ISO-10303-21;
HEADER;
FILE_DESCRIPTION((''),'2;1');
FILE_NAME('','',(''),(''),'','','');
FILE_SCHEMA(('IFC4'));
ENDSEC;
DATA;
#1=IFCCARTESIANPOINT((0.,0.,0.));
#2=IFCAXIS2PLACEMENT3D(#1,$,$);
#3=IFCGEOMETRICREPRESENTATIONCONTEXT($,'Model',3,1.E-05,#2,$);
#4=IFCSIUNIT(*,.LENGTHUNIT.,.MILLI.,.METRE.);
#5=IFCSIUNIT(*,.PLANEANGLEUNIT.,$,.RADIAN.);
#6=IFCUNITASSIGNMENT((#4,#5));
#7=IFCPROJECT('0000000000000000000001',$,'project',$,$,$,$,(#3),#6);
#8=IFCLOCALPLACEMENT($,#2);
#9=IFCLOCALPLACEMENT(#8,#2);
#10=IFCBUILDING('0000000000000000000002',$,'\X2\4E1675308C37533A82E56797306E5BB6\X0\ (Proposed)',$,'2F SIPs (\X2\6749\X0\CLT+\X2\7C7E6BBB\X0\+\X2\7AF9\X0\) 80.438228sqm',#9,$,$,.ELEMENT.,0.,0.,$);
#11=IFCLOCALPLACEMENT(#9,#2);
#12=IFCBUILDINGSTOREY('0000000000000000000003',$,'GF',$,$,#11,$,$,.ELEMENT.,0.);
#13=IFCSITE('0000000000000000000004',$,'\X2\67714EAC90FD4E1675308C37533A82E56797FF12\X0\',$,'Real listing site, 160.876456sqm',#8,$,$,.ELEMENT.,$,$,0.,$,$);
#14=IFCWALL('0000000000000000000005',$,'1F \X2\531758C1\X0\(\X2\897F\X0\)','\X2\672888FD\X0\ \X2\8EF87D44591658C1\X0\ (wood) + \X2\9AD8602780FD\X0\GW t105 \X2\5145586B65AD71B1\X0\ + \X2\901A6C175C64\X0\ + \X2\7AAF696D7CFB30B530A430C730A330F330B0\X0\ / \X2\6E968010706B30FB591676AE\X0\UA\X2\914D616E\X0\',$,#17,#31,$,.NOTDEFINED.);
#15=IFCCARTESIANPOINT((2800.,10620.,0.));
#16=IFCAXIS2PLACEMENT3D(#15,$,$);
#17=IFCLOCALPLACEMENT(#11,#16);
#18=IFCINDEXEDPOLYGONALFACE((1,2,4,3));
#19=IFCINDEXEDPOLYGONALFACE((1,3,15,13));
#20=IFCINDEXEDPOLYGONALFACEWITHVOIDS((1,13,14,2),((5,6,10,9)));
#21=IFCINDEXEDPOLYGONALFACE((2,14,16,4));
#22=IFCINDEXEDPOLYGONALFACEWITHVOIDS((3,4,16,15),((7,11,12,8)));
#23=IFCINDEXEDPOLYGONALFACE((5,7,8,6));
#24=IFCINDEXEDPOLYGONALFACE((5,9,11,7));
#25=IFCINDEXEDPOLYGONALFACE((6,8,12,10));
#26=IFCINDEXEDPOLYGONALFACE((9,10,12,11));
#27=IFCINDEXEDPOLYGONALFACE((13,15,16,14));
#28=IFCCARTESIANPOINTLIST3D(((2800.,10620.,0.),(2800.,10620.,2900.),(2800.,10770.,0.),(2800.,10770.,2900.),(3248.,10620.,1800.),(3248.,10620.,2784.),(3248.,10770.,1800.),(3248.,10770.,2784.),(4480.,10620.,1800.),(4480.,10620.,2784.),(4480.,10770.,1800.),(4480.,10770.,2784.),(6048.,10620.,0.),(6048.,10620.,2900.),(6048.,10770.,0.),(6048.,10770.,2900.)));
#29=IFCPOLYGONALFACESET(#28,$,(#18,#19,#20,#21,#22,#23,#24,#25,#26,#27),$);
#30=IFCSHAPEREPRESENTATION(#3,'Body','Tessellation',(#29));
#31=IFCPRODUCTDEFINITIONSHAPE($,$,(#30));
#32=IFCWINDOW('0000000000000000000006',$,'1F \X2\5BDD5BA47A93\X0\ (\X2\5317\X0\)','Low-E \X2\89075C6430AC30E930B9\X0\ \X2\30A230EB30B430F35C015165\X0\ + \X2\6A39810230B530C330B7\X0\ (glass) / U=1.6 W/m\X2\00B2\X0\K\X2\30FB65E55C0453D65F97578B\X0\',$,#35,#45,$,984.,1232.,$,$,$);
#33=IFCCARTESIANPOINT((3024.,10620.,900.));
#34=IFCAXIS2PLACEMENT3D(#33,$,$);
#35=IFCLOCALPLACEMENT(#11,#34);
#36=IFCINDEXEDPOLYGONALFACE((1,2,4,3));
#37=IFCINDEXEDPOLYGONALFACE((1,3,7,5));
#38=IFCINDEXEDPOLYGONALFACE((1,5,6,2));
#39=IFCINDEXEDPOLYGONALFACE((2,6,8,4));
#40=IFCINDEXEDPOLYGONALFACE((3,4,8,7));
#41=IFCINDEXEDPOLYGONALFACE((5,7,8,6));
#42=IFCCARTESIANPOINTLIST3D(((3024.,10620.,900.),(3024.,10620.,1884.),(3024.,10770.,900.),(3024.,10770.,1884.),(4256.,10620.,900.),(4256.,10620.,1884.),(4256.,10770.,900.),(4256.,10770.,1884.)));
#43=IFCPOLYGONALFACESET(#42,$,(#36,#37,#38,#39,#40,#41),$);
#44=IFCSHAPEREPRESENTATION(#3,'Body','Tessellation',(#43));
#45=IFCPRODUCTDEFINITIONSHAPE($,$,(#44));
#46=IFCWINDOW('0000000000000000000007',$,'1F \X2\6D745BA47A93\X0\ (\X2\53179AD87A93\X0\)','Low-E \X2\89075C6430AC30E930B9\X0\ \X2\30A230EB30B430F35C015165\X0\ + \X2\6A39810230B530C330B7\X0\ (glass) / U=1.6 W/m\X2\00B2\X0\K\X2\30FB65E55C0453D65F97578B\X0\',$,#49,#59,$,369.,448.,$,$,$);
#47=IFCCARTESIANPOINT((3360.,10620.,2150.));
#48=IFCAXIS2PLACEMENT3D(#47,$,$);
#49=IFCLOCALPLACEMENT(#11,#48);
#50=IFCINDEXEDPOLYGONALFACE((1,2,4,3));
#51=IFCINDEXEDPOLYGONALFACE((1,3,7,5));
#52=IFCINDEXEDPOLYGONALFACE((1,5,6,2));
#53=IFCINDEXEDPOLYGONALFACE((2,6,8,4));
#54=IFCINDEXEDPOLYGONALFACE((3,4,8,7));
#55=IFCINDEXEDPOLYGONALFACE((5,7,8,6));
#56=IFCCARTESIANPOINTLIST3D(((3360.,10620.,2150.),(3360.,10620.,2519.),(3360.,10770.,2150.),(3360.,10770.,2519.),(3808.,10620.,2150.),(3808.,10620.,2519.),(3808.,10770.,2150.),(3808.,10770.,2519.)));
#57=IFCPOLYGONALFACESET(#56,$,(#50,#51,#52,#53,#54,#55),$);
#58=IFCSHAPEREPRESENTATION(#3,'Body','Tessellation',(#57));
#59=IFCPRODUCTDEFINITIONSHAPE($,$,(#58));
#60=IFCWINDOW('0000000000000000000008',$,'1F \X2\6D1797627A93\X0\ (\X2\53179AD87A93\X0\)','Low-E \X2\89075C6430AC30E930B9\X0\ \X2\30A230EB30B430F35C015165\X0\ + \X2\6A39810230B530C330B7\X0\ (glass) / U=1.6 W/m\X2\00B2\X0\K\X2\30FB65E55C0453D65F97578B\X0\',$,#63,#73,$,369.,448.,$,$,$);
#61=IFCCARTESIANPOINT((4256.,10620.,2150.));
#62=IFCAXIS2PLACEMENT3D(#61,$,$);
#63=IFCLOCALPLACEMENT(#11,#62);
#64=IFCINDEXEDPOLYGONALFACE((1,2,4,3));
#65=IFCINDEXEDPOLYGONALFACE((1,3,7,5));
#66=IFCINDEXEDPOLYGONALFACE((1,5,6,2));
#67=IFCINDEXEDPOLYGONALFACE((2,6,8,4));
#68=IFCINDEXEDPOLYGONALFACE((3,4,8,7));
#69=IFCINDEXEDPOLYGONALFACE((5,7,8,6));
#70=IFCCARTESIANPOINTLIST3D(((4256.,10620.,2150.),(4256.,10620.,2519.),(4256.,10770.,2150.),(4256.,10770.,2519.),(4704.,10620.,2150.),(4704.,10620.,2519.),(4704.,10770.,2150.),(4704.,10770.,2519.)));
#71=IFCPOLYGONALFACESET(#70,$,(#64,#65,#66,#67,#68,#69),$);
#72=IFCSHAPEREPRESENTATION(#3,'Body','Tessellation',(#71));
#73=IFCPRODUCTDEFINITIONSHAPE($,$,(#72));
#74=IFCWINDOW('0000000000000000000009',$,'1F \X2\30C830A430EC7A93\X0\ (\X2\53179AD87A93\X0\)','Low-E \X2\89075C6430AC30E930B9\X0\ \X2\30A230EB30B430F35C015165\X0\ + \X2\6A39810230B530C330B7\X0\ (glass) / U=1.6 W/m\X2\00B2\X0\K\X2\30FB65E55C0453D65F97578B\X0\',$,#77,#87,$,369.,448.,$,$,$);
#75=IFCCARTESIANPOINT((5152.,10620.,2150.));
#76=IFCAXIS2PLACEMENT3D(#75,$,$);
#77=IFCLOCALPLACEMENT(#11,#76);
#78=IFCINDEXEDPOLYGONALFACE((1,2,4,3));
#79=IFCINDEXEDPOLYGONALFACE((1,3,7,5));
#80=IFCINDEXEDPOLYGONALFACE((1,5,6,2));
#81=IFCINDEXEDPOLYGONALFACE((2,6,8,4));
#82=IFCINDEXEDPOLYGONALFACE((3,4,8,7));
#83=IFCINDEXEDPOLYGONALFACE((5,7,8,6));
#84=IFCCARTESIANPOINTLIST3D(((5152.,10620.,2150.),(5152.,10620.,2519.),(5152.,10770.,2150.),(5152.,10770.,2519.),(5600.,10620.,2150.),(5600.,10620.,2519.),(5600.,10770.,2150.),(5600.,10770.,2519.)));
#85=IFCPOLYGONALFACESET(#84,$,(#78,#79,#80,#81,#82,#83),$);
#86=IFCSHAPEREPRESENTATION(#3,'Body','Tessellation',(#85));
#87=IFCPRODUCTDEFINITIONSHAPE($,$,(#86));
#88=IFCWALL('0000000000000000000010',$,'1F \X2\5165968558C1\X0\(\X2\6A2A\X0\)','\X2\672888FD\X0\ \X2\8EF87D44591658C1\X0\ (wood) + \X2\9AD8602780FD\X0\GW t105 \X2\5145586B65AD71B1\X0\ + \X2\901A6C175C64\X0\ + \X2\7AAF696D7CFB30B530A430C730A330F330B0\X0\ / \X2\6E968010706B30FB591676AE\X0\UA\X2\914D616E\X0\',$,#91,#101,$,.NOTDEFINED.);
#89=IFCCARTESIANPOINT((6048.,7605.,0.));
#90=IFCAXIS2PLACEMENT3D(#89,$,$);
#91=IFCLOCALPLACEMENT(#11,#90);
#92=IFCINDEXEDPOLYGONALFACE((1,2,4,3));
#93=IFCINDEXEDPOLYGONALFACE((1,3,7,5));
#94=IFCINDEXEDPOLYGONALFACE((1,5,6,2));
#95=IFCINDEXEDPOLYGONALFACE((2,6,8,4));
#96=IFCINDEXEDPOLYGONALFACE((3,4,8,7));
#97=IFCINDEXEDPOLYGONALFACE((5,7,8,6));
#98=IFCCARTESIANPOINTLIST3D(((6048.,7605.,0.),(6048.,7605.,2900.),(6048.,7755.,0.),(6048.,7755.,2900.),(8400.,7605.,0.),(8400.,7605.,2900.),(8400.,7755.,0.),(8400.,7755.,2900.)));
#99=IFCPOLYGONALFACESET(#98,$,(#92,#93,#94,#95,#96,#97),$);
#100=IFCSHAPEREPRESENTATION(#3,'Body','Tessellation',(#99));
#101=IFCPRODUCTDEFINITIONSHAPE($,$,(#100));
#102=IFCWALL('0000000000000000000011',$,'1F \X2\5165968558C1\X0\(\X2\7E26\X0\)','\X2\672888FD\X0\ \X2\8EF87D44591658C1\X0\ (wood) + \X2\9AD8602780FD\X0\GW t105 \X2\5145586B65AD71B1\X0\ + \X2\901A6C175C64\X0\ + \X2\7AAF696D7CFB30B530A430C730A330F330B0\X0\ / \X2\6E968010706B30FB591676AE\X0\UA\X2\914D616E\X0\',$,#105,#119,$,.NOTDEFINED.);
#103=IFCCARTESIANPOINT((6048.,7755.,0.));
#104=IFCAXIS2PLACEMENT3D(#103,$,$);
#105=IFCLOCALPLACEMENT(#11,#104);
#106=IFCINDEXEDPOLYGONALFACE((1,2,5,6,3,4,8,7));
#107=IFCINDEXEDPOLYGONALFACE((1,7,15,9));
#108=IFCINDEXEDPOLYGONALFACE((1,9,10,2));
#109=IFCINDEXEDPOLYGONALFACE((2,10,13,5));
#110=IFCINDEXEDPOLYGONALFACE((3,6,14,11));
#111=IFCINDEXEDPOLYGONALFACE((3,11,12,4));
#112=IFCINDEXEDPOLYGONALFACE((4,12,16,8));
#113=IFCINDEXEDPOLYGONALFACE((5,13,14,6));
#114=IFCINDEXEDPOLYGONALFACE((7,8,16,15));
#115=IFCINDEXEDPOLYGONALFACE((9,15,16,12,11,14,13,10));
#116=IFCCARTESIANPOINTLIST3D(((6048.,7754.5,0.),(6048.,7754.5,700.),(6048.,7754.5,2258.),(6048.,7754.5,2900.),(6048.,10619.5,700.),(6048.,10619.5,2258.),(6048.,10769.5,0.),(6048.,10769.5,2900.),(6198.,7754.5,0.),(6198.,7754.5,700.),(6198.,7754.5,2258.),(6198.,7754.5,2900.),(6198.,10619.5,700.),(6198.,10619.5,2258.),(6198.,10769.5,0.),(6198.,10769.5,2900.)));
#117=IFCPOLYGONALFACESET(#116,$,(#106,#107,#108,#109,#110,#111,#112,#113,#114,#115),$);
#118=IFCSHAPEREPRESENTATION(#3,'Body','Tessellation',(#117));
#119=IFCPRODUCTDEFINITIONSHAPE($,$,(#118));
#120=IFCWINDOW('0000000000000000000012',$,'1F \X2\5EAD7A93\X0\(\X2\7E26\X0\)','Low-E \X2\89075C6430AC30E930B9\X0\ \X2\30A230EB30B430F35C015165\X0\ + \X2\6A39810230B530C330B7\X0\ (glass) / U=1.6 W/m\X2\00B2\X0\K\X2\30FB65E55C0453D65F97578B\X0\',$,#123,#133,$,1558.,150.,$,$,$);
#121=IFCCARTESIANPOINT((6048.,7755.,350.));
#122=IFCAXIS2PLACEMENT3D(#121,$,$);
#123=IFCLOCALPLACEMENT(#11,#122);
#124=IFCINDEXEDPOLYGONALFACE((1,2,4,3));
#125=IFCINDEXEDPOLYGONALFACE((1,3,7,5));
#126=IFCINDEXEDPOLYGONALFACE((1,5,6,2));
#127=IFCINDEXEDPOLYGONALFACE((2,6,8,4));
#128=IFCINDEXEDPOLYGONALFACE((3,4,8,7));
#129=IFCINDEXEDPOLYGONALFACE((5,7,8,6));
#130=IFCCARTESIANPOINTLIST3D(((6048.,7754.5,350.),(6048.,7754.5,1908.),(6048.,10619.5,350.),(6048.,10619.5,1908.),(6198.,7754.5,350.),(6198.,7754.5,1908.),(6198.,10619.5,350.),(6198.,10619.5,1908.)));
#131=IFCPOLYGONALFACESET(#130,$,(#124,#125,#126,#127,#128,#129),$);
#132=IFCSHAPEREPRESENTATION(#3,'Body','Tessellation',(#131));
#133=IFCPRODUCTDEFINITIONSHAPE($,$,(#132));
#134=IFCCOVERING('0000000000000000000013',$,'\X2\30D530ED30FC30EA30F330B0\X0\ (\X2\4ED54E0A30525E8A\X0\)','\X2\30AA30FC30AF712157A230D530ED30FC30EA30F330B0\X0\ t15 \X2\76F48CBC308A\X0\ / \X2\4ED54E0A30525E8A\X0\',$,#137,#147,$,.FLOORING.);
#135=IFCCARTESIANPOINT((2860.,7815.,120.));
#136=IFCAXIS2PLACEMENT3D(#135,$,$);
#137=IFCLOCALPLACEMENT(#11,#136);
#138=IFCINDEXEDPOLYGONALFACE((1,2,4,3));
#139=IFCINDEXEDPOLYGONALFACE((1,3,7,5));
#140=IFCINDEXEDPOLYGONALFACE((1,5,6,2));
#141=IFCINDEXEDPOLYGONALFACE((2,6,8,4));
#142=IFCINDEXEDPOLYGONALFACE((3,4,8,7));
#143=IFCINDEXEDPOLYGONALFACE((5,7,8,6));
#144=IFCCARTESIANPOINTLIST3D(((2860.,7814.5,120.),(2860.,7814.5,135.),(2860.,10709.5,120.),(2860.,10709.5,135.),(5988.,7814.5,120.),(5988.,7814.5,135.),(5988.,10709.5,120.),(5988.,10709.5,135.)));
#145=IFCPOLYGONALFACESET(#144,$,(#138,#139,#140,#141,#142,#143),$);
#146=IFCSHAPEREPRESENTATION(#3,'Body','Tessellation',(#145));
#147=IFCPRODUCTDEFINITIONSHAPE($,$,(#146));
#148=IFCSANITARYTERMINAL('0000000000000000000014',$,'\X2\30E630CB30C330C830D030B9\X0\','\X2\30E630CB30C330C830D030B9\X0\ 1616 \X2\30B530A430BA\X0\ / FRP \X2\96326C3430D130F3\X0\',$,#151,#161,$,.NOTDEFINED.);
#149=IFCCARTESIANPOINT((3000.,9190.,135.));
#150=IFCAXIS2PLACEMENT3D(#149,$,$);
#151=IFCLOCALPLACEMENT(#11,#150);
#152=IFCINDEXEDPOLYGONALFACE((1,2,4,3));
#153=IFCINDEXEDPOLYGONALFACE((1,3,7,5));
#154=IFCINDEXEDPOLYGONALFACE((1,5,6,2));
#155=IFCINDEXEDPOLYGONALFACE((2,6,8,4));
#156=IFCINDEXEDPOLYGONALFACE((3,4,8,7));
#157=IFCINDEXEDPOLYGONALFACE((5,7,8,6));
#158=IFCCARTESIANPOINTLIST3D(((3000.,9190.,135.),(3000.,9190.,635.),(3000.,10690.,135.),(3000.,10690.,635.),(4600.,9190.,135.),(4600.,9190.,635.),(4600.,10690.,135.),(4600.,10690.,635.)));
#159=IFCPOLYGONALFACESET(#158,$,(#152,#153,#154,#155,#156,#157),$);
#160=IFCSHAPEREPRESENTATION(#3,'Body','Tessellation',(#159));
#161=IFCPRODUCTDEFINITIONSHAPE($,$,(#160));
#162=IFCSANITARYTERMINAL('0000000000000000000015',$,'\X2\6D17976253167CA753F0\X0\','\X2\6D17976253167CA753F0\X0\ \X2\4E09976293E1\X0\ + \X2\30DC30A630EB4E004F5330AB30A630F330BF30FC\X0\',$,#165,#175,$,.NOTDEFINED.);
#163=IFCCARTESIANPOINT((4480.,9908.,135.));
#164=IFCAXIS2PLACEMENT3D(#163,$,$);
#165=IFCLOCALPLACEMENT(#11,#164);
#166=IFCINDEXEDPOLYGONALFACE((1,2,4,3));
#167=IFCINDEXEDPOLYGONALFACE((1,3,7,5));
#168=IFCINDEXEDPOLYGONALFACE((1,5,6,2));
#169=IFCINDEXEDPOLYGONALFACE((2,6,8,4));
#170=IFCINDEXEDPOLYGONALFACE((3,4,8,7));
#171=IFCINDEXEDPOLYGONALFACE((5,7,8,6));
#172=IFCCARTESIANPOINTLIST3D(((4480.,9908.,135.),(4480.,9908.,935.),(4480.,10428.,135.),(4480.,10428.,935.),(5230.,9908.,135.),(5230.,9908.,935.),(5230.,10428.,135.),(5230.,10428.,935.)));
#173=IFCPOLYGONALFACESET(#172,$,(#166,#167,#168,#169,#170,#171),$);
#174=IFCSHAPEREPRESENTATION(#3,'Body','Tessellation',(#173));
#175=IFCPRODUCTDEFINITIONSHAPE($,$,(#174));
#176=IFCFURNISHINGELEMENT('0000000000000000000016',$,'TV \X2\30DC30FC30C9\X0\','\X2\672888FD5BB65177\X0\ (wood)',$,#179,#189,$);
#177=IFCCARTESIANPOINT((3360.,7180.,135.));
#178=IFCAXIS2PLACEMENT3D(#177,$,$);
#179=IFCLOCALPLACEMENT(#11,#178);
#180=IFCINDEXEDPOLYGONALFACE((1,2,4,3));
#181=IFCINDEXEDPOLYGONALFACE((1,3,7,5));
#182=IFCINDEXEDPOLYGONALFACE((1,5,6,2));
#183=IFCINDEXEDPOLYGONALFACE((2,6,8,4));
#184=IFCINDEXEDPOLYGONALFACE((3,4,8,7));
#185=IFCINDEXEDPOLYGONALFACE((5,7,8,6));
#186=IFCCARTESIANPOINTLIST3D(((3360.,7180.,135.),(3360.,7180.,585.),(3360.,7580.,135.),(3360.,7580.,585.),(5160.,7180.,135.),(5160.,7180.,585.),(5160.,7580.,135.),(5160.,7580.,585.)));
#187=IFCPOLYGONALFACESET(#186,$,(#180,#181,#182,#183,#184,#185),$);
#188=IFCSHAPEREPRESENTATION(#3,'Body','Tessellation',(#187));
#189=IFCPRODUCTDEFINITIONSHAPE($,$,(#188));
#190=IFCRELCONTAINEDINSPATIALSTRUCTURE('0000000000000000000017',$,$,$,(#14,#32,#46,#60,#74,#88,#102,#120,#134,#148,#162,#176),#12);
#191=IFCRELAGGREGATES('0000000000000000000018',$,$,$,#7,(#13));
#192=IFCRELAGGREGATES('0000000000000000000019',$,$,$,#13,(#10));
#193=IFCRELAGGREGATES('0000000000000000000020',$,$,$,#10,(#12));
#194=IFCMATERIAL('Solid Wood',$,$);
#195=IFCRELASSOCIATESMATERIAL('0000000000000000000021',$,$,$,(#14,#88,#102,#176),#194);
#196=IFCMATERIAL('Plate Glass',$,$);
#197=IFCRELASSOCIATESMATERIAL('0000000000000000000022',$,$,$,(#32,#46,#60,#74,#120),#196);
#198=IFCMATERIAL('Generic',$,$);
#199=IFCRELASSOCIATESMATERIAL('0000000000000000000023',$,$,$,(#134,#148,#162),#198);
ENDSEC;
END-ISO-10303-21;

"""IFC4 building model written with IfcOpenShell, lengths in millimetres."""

from ifc_helpers import new_model, si_unit, frame, frame_2d, origin, place, context, project, spatial, rectangle, extrude, material, element, fill, save


model = new_model("IFC4")

# Units and contexts
model_context = context("Model", 3, precision=1e-05, world=origin())
ifc_project = project(units=[si_unit("LENGTHUNIT", "METRE", prefix="MILLI"), si_unit("PLANEANGLEUNIT", "RADIAN")], contexts=[model_context])

# Site, building, storey
site_placement = place(None, origin())
site = spatial("IfcSite", under=ifc_project, at=site_placement, Name="東京都世田谷区若林２", ObjectType="Real listing site, 160.876456sqm", CompositionType="ELEMENT", RefElevation=0.0)
building_placement = place(site_placement, origin())
building = spatial("IfcBuilding", under=site, at=building_placement, Name="世田谷区若林の家 (Proposed)", ObjectType="2F SIPs (杉CLT+籾殻+竹) 80.438228sqm", CompositionType="ELEMENT", ElevationOfRefHeight=0.0, ElevationOfTerrain=0.0)
storey_placement = place(building_placement, origin())
storey = spatial("IfcBuildingStorey", under=building, at=storey_placement, Name="GF", CompositionType="ELEMENT", Elevation=0.0)

# Shared definitions
ifc_material_1 = material(Name="Solid Wood")

# Wall, openings, windows
wall_1_placement = place(storey_placement, frame((2800.0, 10620.0, 0.0)))
wall_1 = element("IfcWall", 1, at=wall_1_placement, inside=storey, material=ifc_material_1, Name="1F 北壁(西)", Description="木製 軸組外壁 (wood) + 高性能GW t105 充填断熱 + 通気層 + 窯業系サイディング / 準耐火・外皮UA配慮", PredefinedType="NOTDEFINED", context=model_context, shape_type="SweptSolid", body=[
    extrude(rectangle(XDim=3248.0, YDim=150.0, at=frame_2d((1624.0, 75.0))), frame((2800.0, 10620.0, 0.0)), (0.0, 0.0, 1.0), 2900.0),
])
opening_1_placement = place(storey_placement, frame((3024.0, 10620.0, 900.0)))
opening_1 = element("IfcOpeningElement", 2, at=opening_1_placement, cuts=wall_1, PredefinedType="NOTDEFINED", context=model_context, shape_type="SweptSolid", body=[
    extrude(rectangle(XDim=1232.0, YDim=150.0, at=frame_2d((616.0, 75.0))), frame((3024.0, 10620.0, 900.0)), (0.0, 0.0, 1.0), 984.0),
])
opening_2_placement = place(storey_placement, frame((3360.0, 10620.0, 2150.0)))
opening_2 = element("IfcOpeningElement", 3, at=opening_2_placement, cuts=wall_1, PredefinedType="NOTDEFINED", context=model_context, shape_type="SweptSolid", body=[
    extrude(rectangle(XDim=448.0, YDim=150.0, at=frame_2d((224.0, 75.0))), frame((3360.0, 10620.0, 2150.0)), (0.0, 0.0, 1.0), 369.0),
])
opening_3_placement = place(storey_placement, frame((4256.0, 10620.0, 2150.0)))
opening_3 = element("IfcOpeningElement", 4, at=opening_3_placement, cuts=wall_1, PredefinedType="NOTDEFINED", context=model_context, shape_type="SweptSolid", body=[
    extrude(rectangle(XDim=448.0, YDim=150.0, at=frame_2d((224.0, 75.0))), frame((4256.0, 10620.0, 2150.0)), (0.0, 0.0, 1.0), 369.0),
])
opening_4_placement = place(storey_placement, frame((5152.0, 10620.0, 2150.0)))
opening_4 = element("IfcOpeningElement", 5, at=opening_4_placement, cuts=wall_1, PredefinedType="NOTDEFINED", context=model_context, shape_type="SweptSolid", body=[
    extrude(rectangle(XDim=448.0, YDim=150.0, at=frame_2d((224.0, 75.0))), frame((5152.0, 10620.0, 2150.0)), (0.0, 0.0, 1.0), 369.0),
])
ifc_material_2 = material(Name="Plate Glass")
window_1_placement = place(storey_placement, frame((3024.0, 10620.0, 900.0)))
window_1 = element("IfcWindow", 6, at=window_1_placement, inside=storey, material=ifc_material_2, Name="1F 寝室窓 (北)", Description="Low-E 複層ガラス アルゴン封入 + 樹脂サッシ (glass) / U=1.6 W/m²K・日射取得型", OverallHeight=984.0, OverallWidth=1232.0, context=model_context, shape_type="SweptSolid", body=[
    extrude(rectangle(XDim=1232.0, YDim=150.0, at=frame_2d((616.0, 75.0))), frame((3024.0, 10620.0, 900.0)), (0.0, 0.0, 1.0), 984.0),
])
fill(opening_1, window_1)
window_2_placement = place(storey_placement, frame((3360.0, 10620.0, 2150.0)))
window_2 = element("IfcWindow", 7, at=window_2_placement, inside=storey, material=ifc_material_2, Name="1F 浴室窓 (北高窓)", Description="Low-E 複層ガラス アルゴン封入 + 樹脂サッシ (glass) / U=1.6 W/m²K・日射取得型", OverallHeight=369.0, OverallWidth=448.0, context=model_context, shape_type="SweptSolid", body=[
    extrude(rectangle(XDim=448.0, YDim=150.0, at=frame_2d((224.0, 75.0))), frame((3360.0, 10620.0, 2150.0)), (0.0, 0.0, 1.0), 369.0),
])
fill(opening_2, window_2)
window_3_placement = place(storey_placement, frame((4256.0, 10620.0, 2150.0)))
window_3 = element("IfcWindow", 8, at=window_3_placement, inside=storey, material=ifc_material_2, Name="1F 洗面窓 (北高窓)", Description="Low-E 複層ガラス アルゴン封入 + 樹脂サッシ (glass) / U=1.6 W/m²K・日射取得型", OverallHeight=369.0, OverallWidth=448.0, context=model_context, shape_type="SweptSolid", body=[
    extrude(rectangle(XDim=448.0, YDim=150.0, at=frame_2d((224.0, 75.0))), frame((4256.0, 10620.0, 2150.0)), (0.0, 0.0, 1.0), 369.0),
])
fill(opening_3, window_3)
window_4_placement = place(storey_placement, frame((5152.0, 10620.0, 2150.0)))
window_4 = element("IfcWindow", 9, at=window_4_placement, inside=storey, material=ifc_material_2, Name="1F トイレ窓 (北高窓)", Description="Low-E 複層ガラス アルゴン封入 + 樹脂サッシ (glass) / U=1.6 W/m²K・日射取得型", OverallHeight=369.0, OverallWidth=448.0, context=model_context, shape_type="SweptSolid", body=[
    extrude(rectangle(XDim=448.0, YDim=150.0, at=frame_2d((224.0, 75.0))), frame((5152.0, 10620.0, 2150.0)), (0.0, 0.0, 1.0), 369.0),
])
fill(opening_4, window_4)

# Wall
wall_2_placement = place(storey_placement, frame((6048.0, 7605.0, 0.0)))
element("IfcWall", 10, at=wall_2_placement, inside=storey, material=ifc_material_1, Name="1F 入隅壁(横)", Description="木製 軸組外壁 (wood) + 高性能GW t105 充填断熱 + 通気層 + 窯業系サイディング / 準耐火・外皮UA配慮", PredefinedType="NOTDEFINED", context=model_context, shape_type="SweptSolid", body=[
    extrude(rectangle(XDim=2352.0, YDim=150.0, at=frame_2d((1176.0, 75.0))), frame((6048.0, 7605.0, 0.0)), (0.0, 0.0, 1.0), 2900.0),
])

# Wall, opening, window
wall_3_placement = place(storey_placement, frame((6048.0, 7755.0, 0.0)))
wall_3 = element("IfcWall", 11, at=wall_3_placement, inside=storey, material=ifc_material_1, Name="1F 入隅壁(縦)", Description="木製 軸組外壁 (wood) + 高性能GW t105 充填断熱 + 通気層 + 窯業系サイディング / 準耐火・外皮UA配慮", PredefinedType="NOTDEFINED", context=model_context, shape_type="SweptSolid", body=[
    extrude(rectangle(XDim=150.0, YDim=3015.0, at=frame_2d((75.0, 1507.0))), frame((6048.0, 7755.0, 0.0)), (0.0, 0.0, 1.0), 2900.0),
])
opening_5_placement = place(storey_placement, frame((6048.0, 7755.0, 350.0)))
opening_5 = element("IfcOpeningElement", 12, at=opening_5_placement, cuts=wall_3, PredefinedType="NOTDEFINED", context=model_context, shape_type="SweptSolid", body=[
    extrude(rectangle(XDim=150.0, YDim=2865.0, at=frame_2d((75.0, 1432.0))), frame((6048.0, 7755.0, 350.0)), (0.0, 0.0, 1.0), 1558.0),
])
window_5_placement = place(storey_placement, frame((6048.0, 7755.0, 350.0)))
window_5 = element("IfcWindow", 13, at=window_5_placement, inside=storey, material=ifc_material_2, Name="1F 庭窓(縦)", Description="Low-E 複層ガラス アルゴン封入 + 樹脂サッシ (glass) / U=1.6 W/m²K・日射取得型", OverallHeight=1558.0, OverallWidth=150.0, context=model_context, shape_type="SweptSolid", body=[
    extrude(rectangle(XDim=150.0, YDim=2865.0, at=frame_2d((75.0, 1432.0))), frame((6048.0, 7755.0, 350.0)), (0.0, 0.0, 1.0), 1558.0),
])
fill(opening_5, window_5)

# Covering
ifc_material_3 = material(Name="Generic")
covering_placement = place(storey_placement, frame((2860.0, 7815.0, 120.0)))
element("IfcCovering", 14, at=covering_placement, inside=storey, material=ifc_material_3, Name="フローリング (仕上げ床)", Description="オーク無垢フローリング t15 直貼り / 仕上げ床", PredefinedType="FLOORING", context=model_context, shape_type="SweptSolid", body=[
    extrude(rectangle(XDim=3128.0, YDim=2895.0, at=frame_2d((1564.0, 1447.0))), frame((2860.0, 7815.0, 120.0)), (0.0, 0.0, 1.0), 15.0),
])

# Sanitary terminals
sanitary_terminal_1_placement = place(storey_placement, frame((3000.0, 9190.0, 135.0)))
element("IfcSanitaryTerminal", 15, at=sanitary_terminal_1_placement, inside=storey, material=ifc_material_3, Name="ユニットバス", Description="ユニットバス 1616 サイズ / FRP 防水パン", PredefinedType="NOTDEFINED", context=model_context, shape_type="SweptSolid", body=[
    extrude(rectangle(XDim=1600.0, YDim=1500.0, at=frame_2d((800.0, 750.0))), frame((3000.0, 9190.0, 135.0)), (0.0, 0.0, 1.0), 500.0),
])
sanitary_terminal_2_placement = place(storey_placement, frame((4480.0, 9908.0, 135.0)))
element("IfcSanitaryTerminal", 16, at=sanitary_terminal_2_placement, inside=storey, material=ifc_material_3, Name="洗面化粧台", Description="洗面化粧台 三面鏡 + ボウル一体カウンター", PredefinedType="NOTDEFINED", context=model_context, shape_type="SweptSolid", body=[
    extrude(rectangle(XDim=750.0, YDim=520.0, at=frame_2d((375.0, 260.0))), frame((4480.0, 9908.0, 135.0)), (0.0, 0.0, 1.0), 800.0),
])

# Furnishing element
furnishing_placement = place(storey_placement, frame((3360.0, 7180.0, 135.0)))
element("IfcFurnishingElement", 17, at=furnishing_placement, inside=storey, material=ifc_material_1, Name="TV ボード", Description="木製家具 (wood)", context=model_context, shape_type="SweptSolid", body=[
    extrude(rectangle(XDim=1800.0, YDim=400.0, at=frame_2d((900.0, 200.0))), frame((3360.0, 7180.0, 135.0)), (0.0, 0.0, 1.0), 450.0),
])

save(model, "model.ifc")
